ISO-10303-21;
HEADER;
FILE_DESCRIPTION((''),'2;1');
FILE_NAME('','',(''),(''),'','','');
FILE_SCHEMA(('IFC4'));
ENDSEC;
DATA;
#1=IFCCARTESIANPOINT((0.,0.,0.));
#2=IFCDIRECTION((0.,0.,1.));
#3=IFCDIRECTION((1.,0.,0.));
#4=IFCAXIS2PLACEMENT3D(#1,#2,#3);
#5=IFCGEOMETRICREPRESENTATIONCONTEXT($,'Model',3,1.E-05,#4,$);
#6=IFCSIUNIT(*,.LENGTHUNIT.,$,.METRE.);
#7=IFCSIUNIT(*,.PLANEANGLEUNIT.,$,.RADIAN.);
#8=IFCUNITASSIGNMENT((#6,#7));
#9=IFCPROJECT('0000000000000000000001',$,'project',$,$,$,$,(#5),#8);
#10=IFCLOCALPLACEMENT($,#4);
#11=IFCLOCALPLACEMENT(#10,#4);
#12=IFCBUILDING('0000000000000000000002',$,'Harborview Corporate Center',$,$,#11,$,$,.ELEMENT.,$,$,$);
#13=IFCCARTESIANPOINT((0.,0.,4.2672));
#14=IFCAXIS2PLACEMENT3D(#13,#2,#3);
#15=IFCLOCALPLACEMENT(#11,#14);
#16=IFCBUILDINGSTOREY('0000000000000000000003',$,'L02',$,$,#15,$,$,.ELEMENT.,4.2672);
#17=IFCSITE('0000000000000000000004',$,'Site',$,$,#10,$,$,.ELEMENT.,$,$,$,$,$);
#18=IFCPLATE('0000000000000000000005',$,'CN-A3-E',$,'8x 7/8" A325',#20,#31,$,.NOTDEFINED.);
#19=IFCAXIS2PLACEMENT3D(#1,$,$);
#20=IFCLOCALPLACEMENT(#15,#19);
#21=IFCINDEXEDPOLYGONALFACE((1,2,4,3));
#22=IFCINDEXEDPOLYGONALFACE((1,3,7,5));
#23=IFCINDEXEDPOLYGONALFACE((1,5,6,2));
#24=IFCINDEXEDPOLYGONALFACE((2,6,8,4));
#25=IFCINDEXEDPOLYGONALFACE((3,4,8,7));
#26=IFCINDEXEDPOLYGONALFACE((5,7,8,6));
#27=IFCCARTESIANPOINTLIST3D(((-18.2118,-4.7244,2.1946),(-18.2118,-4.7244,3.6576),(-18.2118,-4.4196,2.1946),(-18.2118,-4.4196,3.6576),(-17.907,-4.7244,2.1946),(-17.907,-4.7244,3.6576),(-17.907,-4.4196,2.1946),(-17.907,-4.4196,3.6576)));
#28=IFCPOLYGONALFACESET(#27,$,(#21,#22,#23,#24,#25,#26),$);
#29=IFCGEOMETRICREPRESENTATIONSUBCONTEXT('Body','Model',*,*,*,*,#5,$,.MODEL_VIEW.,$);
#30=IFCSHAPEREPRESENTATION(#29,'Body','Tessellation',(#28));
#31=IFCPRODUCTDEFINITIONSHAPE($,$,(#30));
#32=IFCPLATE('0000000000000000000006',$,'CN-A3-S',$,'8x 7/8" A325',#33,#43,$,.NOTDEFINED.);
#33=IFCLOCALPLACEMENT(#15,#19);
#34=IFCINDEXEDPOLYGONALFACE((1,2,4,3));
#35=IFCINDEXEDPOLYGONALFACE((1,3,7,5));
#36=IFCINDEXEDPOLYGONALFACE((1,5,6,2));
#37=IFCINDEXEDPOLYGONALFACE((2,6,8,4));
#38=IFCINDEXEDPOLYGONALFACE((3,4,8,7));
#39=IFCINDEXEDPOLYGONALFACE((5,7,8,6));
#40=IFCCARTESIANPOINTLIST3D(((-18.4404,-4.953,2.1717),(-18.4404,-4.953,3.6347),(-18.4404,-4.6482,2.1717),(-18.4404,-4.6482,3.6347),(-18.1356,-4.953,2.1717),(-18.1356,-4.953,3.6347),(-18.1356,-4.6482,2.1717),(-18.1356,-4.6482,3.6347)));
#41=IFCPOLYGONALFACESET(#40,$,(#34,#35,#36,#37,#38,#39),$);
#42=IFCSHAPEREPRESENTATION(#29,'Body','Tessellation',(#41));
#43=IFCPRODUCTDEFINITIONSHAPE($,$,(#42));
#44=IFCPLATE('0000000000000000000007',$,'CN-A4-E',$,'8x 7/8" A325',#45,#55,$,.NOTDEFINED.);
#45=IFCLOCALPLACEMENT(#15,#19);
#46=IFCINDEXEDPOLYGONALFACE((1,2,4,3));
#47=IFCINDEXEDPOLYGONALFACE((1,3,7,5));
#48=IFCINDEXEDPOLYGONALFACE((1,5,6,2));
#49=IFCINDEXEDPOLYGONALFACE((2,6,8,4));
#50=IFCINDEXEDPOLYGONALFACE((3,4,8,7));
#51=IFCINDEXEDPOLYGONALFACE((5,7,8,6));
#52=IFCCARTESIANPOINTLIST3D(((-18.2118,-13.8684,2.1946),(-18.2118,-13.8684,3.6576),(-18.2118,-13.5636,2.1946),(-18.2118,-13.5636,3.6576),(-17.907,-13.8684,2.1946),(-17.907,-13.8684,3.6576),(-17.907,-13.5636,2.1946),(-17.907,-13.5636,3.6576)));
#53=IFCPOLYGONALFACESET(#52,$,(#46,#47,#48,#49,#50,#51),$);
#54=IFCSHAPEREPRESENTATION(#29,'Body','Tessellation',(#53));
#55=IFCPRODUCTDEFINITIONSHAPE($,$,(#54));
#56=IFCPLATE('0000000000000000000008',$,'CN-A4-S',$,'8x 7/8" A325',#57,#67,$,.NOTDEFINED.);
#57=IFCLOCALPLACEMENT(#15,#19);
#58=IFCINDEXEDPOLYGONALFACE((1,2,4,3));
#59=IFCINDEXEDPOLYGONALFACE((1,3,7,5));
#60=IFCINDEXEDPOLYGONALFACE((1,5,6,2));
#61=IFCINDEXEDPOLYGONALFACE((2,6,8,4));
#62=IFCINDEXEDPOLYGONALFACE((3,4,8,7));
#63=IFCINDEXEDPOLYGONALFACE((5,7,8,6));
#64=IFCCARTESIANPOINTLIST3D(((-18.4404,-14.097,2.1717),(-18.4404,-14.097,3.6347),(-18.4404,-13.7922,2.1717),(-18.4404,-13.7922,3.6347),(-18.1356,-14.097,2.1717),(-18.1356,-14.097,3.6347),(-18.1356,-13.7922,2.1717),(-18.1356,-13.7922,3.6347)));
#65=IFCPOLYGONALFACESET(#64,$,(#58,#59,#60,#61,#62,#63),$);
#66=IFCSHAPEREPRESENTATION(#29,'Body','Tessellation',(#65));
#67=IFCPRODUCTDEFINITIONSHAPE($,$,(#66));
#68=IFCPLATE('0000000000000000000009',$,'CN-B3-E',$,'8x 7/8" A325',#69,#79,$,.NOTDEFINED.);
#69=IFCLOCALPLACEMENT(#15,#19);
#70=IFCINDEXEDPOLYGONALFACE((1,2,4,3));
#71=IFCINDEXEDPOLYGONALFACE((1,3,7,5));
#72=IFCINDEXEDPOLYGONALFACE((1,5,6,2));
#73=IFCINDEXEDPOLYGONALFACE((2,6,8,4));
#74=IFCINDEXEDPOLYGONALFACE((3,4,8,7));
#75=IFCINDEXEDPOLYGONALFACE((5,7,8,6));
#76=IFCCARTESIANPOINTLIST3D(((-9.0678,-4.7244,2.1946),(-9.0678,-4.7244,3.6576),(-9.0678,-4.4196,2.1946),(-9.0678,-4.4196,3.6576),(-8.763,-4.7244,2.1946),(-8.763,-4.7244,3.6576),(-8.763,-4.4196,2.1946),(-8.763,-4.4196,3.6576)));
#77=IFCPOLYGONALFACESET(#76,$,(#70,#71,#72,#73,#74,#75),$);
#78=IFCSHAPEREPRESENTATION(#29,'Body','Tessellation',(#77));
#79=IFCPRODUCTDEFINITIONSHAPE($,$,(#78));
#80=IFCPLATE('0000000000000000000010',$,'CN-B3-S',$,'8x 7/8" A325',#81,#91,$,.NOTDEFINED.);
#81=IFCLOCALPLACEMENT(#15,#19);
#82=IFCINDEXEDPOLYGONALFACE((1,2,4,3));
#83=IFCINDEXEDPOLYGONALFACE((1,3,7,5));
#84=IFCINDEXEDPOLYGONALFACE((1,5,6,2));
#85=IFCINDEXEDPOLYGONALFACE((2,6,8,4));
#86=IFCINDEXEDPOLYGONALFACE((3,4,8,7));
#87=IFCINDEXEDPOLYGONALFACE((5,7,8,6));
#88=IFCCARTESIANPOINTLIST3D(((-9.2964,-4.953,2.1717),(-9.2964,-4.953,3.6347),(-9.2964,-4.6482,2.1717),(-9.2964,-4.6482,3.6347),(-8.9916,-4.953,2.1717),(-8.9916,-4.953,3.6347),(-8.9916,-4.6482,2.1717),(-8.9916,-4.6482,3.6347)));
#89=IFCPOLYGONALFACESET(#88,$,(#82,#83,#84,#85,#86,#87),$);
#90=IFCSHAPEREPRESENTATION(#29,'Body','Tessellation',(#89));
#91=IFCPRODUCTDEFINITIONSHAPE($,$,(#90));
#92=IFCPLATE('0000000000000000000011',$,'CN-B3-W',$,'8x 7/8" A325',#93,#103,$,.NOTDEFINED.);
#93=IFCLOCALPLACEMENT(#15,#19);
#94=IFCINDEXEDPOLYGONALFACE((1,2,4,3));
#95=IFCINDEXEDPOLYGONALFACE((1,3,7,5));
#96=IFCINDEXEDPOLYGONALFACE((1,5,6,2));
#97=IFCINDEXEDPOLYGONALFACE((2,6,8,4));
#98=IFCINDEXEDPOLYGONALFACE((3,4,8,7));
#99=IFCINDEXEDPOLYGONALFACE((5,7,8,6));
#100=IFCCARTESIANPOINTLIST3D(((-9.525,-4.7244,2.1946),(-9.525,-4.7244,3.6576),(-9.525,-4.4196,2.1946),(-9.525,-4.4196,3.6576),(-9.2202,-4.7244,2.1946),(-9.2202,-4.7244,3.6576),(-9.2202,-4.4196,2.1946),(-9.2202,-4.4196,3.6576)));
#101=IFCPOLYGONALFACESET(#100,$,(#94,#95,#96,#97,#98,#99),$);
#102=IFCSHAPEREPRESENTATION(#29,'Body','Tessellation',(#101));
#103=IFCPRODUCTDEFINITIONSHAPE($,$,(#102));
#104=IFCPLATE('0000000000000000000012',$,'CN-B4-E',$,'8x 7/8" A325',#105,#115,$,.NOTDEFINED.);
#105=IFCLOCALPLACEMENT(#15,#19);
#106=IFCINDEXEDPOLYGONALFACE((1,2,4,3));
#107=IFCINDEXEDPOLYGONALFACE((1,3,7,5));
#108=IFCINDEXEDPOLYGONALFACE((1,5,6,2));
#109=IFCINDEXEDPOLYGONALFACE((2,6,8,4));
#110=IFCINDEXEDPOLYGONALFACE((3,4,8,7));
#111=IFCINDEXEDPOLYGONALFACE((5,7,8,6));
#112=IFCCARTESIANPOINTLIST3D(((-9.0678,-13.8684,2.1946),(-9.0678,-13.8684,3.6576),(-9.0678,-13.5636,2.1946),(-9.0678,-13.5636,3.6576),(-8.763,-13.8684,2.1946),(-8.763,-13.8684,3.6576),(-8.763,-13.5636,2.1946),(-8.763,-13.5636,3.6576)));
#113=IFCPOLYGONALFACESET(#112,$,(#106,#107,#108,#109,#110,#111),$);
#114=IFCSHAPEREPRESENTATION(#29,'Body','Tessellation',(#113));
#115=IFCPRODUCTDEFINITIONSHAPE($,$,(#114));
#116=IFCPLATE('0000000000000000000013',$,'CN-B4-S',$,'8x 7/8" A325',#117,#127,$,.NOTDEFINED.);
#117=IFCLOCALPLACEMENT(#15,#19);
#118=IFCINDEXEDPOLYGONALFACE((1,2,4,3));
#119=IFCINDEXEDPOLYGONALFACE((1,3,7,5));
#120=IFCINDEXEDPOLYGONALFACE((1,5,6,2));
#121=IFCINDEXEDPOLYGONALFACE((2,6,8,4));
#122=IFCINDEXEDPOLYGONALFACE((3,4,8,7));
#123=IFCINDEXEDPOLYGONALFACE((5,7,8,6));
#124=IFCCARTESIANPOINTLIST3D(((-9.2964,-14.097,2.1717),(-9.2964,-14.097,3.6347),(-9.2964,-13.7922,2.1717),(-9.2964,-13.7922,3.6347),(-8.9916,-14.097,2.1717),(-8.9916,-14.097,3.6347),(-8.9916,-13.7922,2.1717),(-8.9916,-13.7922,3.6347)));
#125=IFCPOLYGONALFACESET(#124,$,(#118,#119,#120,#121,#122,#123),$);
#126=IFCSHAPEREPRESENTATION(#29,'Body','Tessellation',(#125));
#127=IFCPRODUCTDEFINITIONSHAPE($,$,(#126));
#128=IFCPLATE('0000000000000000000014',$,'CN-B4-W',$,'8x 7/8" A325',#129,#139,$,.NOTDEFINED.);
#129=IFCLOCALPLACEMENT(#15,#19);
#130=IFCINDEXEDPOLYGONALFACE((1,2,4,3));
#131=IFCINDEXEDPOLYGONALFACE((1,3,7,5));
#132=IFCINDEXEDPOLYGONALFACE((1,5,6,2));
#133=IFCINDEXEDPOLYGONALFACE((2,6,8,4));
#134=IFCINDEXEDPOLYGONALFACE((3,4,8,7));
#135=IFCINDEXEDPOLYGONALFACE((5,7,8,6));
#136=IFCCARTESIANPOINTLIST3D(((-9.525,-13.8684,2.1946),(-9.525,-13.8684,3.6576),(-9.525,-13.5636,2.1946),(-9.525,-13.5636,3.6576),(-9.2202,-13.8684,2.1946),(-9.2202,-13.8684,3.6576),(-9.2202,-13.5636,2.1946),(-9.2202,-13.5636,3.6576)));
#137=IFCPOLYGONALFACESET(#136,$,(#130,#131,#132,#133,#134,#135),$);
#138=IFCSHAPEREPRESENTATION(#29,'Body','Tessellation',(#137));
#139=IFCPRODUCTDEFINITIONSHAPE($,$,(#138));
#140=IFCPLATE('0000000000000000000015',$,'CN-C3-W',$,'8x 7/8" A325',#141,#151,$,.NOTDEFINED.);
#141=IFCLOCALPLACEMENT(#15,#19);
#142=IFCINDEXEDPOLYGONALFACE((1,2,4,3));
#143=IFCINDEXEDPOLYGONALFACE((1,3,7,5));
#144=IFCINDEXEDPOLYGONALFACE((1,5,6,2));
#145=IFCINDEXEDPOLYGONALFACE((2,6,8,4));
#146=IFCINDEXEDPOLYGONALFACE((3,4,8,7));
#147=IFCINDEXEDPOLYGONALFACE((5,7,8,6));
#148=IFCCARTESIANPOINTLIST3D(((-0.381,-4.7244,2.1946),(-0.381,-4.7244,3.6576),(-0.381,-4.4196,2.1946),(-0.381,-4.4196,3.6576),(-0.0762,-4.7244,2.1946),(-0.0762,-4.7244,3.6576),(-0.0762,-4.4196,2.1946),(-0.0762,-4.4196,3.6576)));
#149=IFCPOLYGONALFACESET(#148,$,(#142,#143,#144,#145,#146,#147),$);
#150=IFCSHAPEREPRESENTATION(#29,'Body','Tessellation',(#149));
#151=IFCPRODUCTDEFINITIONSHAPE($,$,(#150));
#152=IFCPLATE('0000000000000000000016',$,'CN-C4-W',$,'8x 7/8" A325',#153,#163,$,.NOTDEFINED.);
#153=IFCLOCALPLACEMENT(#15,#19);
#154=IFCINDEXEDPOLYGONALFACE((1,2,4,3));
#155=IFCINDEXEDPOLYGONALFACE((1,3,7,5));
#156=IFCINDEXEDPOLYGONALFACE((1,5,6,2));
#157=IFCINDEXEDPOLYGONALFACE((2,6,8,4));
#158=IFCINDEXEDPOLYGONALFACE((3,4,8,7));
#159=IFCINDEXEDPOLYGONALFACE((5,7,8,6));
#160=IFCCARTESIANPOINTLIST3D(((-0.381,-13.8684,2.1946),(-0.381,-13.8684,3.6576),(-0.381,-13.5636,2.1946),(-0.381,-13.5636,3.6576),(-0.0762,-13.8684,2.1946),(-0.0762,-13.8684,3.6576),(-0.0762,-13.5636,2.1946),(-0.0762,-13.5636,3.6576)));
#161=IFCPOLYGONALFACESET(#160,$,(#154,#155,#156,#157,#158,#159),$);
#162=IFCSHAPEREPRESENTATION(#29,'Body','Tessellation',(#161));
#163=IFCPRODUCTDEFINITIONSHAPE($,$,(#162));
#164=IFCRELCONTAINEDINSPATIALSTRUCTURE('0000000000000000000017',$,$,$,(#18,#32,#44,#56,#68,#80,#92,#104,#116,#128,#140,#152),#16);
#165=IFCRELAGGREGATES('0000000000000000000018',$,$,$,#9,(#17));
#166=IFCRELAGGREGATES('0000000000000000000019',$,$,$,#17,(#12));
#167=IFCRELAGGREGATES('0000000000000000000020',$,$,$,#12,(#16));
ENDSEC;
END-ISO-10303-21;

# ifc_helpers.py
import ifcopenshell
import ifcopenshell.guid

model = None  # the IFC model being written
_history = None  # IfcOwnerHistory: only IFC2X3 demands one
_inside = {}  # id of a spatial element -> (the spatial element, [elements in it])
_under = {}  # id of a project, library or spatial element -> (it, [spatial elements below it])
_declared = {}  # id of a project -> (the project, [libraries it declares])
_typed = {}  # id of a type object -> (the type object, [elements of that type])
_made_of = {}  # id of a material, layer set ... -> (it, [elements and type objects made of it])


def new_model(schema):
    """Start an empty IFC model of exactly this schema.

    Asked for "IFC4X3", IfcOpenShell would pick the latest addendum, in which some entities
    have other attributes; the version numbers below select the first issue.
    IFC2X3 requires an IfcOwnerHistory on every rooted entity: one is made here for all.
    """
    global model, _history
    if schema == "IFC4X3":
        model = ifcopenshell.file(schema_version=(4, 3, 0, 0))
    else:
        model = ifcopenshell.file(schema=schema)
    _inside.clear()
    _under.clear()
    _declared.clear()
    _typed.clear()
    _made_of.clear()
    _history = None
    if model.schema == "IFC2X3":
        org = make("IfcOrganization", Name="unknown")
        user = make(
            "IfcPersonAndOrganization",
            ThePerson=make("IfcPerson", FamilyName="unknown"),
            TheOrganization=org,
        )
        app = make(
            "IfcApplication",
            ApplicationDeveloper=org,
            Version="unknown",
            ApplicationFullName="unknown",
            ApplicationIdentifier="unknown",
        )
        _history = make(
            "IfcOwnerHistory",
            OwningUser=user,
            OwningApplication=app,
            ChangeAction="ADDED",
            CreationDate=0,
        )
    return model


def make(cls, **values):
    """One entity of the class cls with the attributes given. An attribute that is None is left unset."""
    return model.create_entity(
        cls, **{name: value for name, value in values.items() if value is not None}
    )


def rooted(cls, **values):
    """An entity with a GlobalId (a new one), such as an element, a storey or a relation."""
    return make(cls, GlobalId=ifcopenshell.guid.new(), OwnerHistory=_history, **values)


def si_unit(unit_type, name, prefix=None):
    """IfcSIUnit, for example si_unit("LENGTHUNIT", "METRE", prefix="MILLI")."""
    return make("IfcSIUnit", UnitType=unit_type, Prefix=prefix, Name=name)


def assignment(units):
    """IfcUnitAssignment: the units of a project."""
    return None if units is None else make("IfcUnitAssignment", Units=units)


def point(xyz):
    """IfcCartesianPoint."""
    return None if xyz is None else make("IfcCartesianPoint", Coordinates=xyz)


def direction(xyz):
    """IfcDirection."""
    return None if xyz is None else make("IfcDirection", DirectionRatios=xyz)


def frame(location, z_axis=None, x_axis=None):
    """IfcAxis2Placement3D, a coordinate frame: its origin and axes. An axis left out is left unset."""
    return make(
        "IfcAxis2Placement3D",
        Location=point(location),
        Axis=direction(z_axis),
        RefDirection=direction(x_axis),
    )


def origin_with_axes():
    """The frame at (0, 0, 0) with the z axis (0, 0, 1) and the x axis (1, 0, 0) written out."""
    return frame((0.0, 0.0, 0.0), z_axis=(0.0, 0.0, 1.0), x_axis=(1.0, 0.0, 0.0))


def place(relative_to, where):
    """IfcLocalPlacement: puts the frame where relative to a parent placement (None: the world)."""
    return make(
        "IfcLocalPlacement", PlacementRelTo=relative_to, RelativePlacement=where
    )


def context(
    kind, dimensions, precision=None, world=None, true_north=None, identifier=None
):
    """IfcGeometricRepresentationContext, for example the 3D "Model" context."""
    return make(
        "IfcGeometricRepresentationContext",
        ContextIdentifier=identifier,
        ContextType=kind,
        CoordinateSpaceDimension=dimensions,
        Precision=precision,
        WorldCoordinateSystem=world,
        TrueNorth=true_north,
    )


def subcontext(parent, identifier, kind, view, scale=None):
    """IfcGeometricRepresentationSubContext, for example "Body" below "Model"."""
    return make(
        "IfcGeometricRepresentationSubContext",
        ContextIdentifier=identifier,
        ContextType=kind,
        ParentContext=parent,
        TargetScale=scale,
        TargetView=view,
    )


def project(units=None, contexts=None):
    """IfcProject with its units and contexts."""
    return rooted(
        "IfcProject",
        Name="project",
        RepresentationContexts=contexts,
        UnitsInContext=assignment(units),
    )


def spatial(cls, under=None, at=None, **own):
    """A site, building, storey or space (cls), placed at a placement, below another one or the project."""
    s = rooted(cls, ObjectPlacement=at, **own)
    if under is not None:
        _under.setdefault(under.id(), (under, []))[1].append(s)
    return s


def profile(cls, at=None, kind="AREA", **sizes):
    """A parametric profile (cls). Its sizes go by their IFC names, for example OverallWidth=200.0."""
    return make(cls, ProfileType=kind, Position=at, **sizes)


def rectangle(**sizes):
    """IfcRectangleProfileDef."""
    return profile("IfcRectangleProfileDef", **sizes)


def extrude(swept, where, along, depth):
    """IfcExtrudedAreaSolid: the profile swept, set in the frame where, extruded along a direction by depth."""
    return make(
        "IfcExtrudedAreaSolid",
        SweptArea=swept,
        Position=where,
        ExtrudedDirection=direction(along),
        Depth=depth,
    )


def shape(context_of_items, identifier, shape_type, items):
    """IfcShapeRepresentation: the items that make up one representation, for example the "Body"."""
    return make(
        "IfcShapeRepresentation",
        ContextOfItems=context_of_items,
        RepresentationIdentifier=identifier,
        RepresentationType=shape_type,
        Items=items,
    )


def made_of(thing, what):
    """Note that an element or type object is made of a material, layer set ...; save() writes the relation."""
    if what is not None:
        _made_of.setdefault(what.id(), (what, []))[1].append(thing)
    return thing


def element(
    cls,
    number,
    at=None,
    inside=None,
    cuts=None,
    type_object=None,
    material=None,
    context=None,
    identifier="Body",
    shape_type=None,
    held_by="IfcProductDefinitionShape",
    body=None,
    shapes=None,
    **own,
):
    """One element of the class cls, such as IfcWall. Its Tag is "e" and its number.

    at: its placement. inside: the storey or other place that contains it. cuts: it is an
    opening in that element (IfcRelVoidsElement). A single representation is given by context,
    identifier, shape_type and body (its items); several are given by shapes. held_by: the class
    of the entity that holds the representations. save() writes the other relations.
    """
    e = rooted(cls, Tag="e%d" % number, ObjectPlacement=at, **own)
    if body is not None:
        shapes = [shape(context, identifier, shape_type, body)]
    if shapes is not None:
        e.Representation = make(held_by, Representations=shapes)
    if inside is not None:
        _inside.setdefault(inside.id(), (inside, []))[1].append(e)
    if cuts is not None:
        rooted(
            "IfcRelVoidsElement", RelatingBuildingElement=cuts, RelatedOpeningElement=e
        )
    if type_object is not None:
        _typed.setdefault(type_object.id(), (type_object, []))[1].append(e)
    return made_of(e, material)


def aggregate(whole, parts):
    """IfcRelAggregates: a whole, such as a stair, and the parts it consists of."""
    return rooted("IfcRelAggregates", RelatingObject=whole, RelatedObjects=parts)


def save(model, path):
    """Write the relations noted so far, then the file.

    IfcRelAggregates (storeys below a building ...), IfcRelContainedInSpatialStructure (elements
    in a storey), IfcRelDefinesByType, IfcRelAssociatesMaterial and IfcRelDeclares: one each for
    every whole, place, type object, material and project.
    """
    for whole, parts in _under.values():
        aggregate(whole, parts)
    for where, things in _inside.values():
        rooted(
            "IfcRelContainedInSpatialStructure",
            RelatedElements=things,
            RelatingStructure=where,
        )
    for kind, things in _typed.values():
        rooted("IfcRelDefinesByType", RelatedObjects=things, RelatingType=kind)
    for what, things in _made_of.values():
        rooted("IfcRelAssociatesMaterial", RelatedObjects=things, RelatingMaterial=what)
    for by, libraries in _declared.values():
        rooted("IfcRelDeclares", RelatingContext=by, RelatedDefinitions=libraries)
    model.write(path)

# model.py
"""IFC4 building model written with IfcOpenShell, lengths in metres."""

from ifc_helpers import new_model, si_unit, frame, origin_with_axes, place, context, subcontext, project, spatial, rectangle, extrude, element, save


model = new_model("IFC4")

# Units and contexts
model_context = context("Model", 3, precision=1e-05, world=origin_with_axes())
body_context = subcontext(model_context, "Body", "Model", "MODEL_VIEW")
ifc_project = project(units=[si_unit("LENGTHUNIT", "METRE"), si_unit("PLANEANGLEUNIT", "RADIAN")], contexts=[model_context])

# Site, building, storey
site_placement = place(None, origin_with_axes())
site = spatial("IfcSite", under=ifc_project, at=site_placement, Name="Site", CompositionType="ELEMENT")
building_placement = place(site_placement, origin_with_axes())
building = spatial("IfcBuilding", under=site, at=building_placement, Name="Harborview Corporate Center", CompositionType="ELEMENT")
storey_placement = place(building_placement, frame((0.0, 0.0, 4.2672), z_axis=(0.0, 0.0, 1.0), x_axis=(1.0, 0.0, 0.0)))
storey = spatial("IfcBuildingStorey", under=building, at=storey_placement, Name="L02", CompositionType="ELEMENT", Elevation=4.2672)

# Plates
for number, where, z_axis, x_axis, name in (
    (1, (-18.0594, -4.572, 2.1946), (0.0, 0.0, 1.0), (1.0, 0.0, 0.0), "CN-A3-E"),
    (2, (-18.288, -4.8006, 2.1717), (0.0, 0.0, 1.0), (1.0, 0.0, 0.0), "CN-A3-S"),
    (3, (-18.0594, -13.716, 2.1946), (0.0, 0.0, 1.0), (1.0, 0.0, 0.0), "CN-A4-E"),
    (4, (-18.288, -13.9446, 2.1717), (0.0, 0.0, 1.0), (1.0, 0.0, 0.0), "CN-A4-S"),
    (5, (-8.9154, -4.572, 2.1946), (0.0, 0.0, 1.0), (1.0, 0.0, 0.0), "CN-B3-E"),
    (6, (-9.144, -4.8006, 2.1717), (0.0, 0.0, 1.0), (1.0, 0.0, 0.0), "CN-B3-S"),
    (7, (-9.3726, -4.572, 2.1946), (0.0, 0.0, 1.0), (1.0, 0.0, 0.0), "CN-B3-W"),
    (8, (-8.9154, -13.716, 2.1946), (0.0, 0.0, 1.0), (1.0, 0.0, 0.0), "CN-B4-E"),
    (9, (-9.144, -13.9446, 2.1717), (0.0, 0.0, 1.0), (1.0, 0.0, 0.0), "CN-B4-S"),
    (10, (-9.3726, -13.716, 2.1946), (0.0, 0.0, 1.0), (1.0, 0.0, 0.0), "CN-B4-W"),
):
    element("IfcPlate", number, at=place(storey_placement, frame(where, z_axis=z_axis, x_axis=x_axis)), inside=storey, Name=name, ObjectType="8x 7/8\" A325", PredefinedType="NOTDEFINED", context=body_context, shape_type="SweptSolid", body=[
        extrude(rectangle(XDim=0.3048, YDim=0.3048), origin_with_axes(), (0.0, 0.0, 1.0), 1.463),
    ])
for number, where, z_axis, x_axis, name in (
    (11, (-0.2286, -4.572, 2.1946), (0.0, 0.0, 1.0), (1.0, 0.0, 0.0), "CN-C3-W"),
    (12, (-0.2286, -13.716, 2.1946), (0.0, 0.0, 1.0), (1.0, 0.0, 0.0), "CN-C4-W"),
):
    element("IfcPlate", number, at=place(storey_placement, frame(where, z_axis=z_axis, x_axis=x_axis)), inside=storey, Name=name, ObjectType="8x 7/8\" A325", PredefinedType="NOTDEFINED", context=body_context, shape_type="SweptSolid", body=[
        extrude(rectangle(XDim=0.3048, YDim=0.3048), origin_with_axes(), (0.0, 0.0, 1.0), 1.463),
    ])

save(model, "model.ifc")
